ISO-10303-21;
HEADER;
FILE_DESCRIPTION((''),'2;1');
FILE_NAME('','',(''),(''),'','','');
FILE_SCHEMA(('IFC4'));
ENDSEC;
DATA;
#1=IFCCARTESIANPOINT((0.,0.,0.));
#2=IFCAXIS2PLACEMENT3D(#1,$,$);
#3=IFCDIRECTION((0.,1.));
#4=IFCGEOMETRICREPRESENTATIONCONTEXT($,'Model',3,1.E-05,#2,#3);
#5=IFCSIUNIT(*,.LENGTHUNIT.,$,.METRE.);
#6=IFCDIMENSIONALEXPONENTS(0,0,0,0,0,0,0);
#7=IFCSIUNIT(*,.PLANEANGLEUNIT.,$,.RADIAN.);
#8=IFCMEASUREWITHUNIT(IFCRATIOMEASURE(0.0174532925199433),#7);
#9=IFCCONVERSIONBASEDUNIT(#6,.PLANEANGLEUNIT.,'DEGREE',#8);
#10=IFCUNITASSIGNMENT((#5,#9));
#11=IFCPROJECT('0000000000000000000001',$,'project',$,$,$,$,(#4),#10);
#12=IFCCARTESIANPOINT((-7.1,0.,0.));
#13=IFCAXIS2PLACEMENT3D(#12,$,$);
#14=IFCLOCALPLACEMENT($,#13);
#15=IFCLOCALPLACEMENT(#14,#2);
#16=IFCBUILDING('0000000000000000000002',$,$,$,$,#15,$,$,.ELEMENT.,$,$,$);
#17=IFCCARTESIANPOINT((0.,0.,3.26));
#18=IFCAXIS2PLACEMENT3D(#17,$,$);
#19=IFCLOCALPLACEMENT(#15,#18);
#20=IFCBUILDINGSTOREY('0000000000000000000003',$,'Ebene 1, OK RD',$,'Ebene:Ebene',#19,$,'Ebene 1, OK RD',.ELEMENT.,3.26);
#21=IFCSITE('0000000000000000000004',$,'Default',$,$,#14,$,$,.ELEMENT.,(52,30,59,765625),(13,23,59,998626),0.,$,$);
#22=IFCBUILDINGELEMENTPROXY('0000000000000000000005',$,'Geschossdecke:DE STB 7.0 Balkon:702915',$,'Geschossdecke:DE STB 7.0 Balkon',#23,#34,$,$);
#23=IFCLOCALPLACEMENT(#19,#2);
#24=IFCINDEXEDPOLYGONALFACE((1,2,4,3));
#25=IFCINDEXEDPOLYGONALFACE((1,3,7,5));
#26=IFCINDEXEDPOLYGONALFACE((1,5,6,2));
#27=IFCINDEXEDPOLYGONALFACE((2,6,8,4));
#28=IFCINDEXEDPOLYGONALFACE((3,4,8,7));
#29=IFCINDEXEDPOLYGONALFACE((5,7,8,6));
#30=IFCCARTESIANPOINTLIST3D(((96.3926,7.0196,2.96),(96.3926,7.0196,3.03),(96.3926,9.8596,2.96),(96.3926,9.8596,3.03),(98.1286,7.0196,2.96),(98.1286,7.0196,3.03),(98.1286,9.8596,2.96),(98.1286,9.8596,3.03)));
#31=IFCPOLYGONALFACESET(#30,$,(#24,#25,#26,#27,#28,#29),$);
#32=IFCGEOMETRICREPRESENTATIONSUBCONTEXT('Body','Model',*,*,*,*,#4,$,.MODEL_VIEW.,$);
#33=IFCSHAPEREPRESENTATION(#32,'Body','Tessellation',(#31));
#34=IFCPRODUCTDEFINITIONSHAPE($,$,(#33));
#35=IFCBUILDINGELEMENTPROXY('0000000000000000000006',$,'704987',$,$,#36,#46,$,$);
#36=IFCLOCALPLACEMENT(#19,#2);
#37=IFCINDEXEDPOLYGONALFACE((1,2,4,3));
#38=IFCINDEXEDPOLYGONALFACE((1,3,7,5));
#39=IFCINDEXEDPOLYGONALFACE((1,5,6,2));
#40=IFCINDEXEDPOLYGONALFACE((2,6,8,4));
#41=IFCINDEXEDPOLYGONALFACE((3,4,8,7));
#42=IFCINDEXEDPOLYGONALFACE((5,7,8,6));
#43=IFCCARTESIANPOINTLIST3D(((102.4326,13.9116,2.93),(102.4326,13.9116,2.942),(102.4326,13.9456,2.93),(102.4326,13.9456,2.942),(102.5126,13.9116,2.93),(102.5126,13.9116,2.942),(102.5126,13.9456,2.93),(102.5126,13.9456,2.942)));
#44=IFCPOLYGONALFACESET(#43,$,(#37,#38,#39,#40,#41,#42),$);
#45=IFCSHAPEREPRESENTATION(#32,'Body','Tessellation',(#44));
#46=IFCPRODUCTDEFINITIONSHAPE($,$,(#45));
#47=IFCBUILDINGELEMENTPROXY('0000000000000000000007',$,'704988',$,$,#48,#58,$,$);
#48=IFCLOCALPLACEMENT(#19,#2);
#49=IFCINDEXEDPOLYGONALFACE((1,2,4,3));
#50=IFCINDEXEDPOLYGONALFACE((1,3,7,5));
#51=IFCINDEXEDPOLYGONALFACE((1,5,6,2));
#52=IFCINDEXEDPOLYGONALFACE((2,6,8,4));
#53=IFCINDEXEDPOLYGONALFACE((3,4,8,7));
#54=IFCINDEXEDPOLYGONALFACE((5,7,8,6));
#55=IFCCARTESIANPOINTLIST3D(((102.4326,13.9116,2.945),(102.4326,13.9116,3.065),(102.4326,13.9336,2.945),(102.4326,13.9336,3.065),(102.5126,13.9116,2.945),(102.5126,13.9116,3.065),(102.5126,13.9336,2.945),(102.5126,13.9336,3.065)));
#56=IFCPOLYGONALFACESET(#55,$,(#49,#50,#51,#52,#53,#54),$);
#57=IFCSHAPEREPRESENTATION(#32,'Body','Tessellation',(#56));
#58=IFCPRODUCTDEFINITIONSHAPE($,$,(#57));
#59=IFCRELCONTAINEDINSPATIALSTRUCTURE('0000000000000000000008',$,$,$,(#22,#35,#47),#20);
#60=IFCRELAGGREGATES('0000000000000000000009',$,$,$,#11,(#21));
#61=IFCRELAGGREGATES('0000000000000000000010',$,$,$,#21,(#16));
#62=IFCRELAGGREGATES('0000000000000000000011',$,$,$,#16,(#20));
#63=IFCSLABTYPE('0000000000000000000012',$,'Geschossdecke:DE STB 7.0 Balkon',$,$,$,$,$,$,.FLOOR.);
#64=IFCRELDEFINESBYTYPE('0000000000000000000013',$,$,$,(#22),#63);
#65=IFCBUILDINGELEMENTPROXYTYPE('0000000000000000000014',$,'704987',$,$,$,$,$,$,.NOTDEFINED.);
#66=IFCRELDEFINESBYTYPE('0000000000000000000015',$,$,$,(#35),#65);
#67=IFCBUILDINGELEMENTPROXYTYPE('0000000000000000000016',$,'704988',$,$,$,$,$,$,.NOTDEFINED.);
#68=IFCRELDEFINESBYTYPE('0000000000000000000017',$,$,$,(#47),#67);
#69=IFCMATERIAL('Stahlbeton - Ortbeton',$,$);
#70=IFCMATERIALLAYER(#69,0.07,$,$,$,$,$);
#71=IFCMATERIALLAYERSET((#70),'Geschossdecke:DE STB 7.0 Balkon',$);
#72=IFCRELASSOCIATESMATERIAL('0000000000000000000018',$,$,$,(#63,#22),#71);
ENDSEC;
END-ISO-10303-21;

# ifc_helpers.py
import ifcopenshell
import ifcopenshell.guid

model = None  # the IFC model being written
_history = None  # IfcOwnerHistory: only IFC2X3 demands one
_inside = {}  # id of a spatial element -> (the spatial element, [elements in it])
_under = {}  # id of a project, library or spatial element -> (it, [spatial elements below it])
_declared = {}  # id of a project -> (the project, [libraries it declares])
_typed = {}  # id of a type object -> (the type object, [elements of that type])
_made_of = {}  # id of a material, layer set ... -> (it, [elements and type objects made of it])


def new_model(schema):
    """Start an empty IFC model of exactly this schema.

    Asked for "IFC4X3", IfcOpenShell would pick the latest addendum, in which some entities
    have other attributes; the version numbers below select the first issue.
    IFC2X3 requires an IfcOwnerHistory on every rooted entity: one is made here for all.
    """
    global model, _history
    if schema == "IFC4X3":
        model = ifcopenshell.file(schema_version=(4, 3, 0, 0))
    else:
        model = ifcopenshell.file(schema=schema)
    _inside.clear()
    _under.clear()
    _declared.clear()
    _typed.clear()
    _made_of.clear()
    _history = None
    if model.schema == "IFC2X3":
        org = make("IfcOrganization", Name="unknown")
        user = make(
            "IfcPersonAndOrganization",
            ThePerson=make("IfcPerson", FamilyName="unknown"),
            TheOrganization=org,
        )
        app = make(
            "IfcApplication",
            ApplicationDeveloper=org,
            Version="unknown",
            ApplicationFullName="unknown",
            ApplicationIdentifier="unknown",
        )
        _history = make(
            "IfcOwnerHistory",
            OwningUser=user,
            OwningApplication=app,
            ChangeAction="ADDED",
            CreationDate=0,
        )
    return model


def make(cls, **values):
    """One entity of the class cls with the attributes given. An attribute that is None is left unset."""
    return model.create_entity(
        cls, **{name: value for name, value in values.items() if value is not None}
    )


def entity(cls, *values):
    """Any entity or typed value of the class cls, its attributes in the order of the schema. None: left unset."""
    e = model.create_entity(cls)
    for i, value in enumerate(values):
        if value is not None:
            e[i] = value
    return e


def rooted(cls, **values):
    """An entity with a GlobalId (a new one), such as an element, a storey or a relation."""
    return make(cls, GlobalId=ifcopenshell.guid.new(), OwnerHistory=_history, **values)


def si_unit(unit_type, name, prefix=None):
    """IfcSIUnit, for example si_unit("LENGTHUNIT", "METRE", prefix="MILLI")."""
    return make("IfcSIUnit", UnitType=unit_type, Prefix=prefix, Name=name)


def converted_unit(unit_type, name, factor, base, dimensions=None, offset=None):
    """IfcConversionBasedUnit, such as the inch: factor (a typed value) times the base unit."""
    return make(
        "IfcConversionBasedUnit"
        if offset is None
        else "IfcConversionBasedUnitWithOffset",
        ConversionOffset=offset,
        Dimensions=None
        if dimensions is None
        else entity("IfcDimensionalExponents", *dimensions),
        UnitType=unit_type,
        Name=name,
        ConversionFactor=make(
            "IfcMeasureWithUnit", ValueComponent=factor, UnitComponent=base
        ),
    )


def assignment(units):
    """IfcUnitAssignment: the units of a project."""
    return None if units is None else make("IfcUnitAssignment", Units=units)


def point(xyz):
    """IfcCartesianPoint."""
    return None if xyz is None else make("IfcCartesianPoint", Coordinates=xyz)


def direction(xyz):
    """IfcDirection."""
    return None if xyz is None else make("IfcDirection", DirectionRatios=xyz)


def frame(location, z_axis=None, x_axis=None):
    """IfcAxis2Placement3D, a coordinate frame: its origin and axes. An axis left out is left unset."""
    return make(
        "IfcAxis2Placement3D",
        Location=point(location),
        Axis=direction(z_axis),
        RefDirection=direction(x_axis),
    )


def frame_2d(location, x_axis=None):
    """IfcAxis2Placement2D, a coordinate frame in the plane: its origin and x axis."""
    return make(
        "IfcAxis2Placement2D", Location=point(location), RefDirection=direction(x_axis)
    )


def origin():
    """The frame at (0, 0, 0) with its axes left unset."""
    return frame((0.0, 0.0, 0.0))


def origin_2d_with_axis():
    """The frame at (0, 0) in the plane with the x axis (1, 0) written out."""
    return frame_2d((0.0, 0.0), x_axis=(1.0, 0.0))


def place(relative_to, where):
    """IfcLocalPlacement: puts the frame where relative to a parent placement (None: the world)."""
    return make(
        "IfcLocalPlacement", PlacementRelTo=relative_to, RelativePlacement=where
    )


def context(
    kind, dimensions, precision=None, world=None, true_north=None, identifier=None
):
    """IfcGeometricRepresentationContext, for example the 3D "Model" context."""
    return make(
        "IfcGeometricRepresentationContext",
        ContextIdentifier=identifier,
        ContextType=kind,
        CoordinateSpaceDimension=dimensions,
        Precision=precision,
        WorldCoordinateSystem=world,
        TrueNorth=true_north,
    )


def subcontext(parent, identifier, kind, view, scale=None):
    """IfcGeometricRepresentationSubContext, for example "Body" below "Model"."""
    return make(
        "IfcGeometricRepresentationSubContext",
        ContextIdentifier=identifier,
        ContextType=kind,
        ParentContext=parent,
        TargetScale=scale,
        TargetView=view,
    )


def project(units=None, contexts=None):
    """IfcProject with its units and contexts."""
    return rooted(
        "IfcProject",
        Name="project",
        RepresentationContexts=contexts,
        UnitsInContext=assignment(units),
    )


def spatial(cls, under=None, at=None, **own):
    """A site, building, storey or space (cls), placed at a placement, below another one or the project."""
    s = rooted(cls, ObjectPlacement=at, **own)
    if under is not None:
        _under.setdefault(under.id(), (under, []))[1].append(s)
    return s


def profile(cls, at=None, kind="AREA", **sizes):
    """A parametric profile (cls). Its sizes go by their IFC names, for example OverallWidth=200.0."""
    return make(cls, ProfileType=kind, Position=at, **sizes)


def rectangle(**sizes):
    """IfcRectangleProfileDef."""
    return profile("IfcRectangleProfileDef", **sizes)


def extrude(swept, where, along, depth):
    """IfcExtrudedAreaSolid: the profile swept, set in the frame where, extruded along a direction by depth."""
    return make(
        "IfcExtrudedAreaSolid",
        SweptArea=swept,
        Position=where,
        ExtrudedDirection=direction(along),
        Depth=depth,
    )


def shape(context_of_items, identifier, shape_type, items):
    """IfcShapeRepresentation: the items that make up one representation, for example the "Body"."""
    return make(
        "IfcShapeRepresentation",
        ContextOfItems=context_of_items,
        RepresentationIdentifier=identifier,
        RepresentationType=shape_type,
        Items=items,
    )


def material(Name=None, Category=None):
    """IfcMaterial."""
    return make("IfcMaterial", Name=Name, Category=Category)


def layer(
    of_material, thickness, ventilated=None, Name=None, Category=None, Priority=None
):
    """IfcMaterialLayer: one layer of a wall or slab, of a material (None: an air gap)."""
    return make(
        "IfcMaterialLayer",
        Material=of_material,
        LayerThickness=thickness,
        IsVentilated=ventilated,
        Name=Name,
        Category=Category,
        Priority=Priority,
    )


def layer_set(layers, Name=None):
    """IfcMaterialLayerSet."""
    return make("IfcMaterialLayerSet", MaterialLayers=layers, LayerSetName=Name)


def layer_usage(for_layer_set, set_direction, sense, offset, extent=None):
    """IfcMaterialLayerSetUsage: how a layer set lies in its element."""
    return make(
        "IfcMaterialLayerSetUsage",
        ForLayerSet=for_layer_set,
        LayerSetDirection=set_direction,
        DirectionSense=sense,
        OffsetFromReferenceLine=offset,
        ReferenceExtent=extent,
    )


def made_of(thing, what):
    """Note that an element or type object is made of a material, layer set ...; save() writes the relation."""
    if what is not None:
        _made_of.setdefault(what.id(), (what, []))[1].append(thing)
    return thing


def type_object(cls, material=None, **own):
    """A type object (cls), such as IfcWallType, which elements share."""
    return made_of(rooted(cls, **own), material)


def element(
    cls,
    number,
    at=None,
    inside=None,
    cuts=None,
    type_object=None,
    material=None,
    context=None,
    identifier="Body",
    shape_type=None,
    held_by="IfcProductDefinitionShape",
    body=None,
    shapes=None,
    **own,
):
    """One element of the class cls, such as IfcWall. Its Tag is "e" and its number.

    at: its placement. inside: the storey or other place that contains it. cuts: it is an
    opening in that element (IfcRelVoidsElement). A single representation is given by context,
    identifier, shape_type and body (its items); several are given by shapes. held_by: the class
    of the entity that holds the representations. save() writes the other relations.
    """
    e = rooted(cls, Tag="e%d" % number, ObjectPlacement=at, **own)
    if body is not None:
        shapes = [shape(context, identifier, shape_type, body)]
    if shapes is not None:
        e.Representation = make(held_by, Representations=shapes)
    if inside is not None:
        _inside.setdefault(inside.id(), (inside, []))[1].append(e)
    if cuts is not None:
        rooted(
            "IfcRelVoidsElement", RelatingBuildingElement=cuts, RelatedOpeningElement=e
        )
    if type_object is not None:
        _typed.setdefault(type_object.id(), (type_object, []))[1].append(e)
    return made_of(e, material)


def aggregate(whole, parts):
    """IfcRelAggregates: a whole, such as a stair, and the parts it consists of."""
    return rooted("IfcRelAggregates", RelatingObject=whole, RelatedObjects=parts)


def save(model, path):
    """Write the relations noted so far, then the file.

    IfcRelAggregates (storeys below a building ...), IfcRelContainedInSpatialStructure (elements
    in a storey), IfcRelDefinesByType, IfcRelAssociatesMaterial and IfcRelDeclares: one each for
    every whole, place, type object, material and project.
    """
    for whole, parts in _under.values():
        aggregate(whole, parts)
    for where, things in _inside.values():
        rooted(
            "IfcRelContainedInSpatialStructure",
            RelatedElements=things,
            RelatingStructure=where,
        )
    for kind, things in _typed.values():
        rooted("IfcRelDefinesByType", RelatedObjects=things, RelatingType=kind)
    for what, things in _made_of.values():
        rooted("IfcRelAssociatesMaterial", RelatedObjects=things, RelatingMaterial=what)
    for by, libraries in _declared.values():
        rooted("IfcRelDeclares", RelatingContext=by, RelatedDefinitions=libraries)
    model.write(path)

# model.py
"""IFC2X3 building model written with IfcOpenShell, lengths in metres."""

from ifc_helpers import new_model, entity, si_unit, converted_unit, direction, frame, frame_2d, origin, origin_2d_with_axis, place, context, subcontext, project, spatial, rectangle, extrude, material, layer, layer_set, layer_usage, type_object, element, save


model = new_model("IFC2X3")

# Units and contexts
model_context = context("Model", 3, precision=1e-05, world=origin(), true_north=direction((0.0, 1.0)))
body_context = subcontext(model_context, "Body", "Model", "MODEL_VIEW")
ifc_project = project(units=[si_unit("LENGTHUNIT", "METRE"), converted_unit("PLANEANGLEUNIT", "DEGREE", entity("IfcRatioMeasure", 0.0174532925199433), si_unit("PLANEANGLEUNIT", "RADIAN"), dimensions=[0, 0, 0, 0, 0, 0, 0])], contexts=[model_context])

# Site, building, storey
site_placement = place(None, frame((-7.1, 0.0, 0.0)))
site = spatial("IfcSite", under=ifc_project, at=site_placement, Name="Default", CompositionType="ELEMENT", RefLatitude=(52, 30, 59, 765625), RefLongitude=(13, 23, 59, 998626), RefElevation=0.0)
building_placement = place(site_placement, origin())
building = spatial("IfcBuilding", under=site, at=building_placement, CompositionType="ELEMENT")
storey_placement = place(building_placement, frame((0.0, 0.0, 3.26)))
storey = spatial("IfcBuildingStorey", under=building, at=storey_placement, Name="Ebene 1, OK RD", ObjectType="Ebene:Ebene", LongName="Ebene 1, OK RD", CompositionType="ELEMENT", Elevation=3.26)

# Shared definitions
ifc_material_1 = material(Name="Stahlbeton - Ortbeton")
ifc_layer_1 = layer(ifc_material_1, 0.07)
ifc_layer_set_1 = layer_set([ifc_layer_1], Name="Geschossdecke:DE STB 7.0 Balkon")

# Building element proxies
ifc_layer_usage_1 = layer_usage(ifc_layer_set_1, "AXIS3", "POSITIVE", 0.0)
slab_type_1 = type_object("IfcSlabType", Name="Geschossdecke:DE STB 7.0 Balkon", PredefinedType="FLOOR", material=ifc_layer_set_1)
proxy_1_placement = place(storey_placement, origin())
element("IfcBuildingElementProxy", 1, at=proxy_1_placement, inside=storey, type_object=slab_type_1, material=ifc_layer_usage_1, Name="Geschossdecke:DE STB 7.0 Balkon:702915", ObjectType="Geschossdecke:DE STB 7.0 Balkon", context=body_context, shape_type="SweptSolid", body=[
    extrude(rectangle(XDim=2.84, YDim=1.736, at=origin_2d_with_axis()), frame((97.2606, 8.4396, 3.03), z_axis=(0.0, 0.0, -1.0), x_axis=(0.0, 1.0, 0.0)), (0.0, 0.0, 1.0), 0.07),
])
building_element_proxy_type_1 = type_object("IfcBuildingElementProxyType", Name="704987", PredefinedType="NOTDEFINED")
proxy_2_placement = place(storey_placement, origin())
element("IfcBuildingElementProxy", 2, at=proxy_2_placement, inside=storey, type_object=building_element_proxy_type_1, Name="704987", context=body_context, shape_type="SweptSolid", body=[
    extrude(rectangle(XDim=0.08, YDim=0.034, at=frame_2d((0.0, 0.0), x_axis=(1.0, 0.0))), frame((102.4726, 13.9286, 2.93)), (0.0, 0.0, 1.0), 0.012),
])
building_element_proxy_type_2 = type_object("IfcBuildingElementProxyType", Name="704988", PredefinedType="NOTDEFINED")
proxy_3_placement = place(storey_placement, origin())
element("IfcBuildingElementProxy", 3, at=proxy_3_placement, inside=storey, type_object=building_element_proxy_type_2, Name="704988", context=body_context, shape_type="SweptSolid", body=[
    extrude(rectangle(XDim=0.08, YDim=0.022, at=frame_2d((0.0, 0.0), x_axis=(1.0, 0.0))), frame((102.4726, 13.9226, 2.945)), (0.0, 0.0, 1.0), 0.12),
])

save(model, "model.ifc")
